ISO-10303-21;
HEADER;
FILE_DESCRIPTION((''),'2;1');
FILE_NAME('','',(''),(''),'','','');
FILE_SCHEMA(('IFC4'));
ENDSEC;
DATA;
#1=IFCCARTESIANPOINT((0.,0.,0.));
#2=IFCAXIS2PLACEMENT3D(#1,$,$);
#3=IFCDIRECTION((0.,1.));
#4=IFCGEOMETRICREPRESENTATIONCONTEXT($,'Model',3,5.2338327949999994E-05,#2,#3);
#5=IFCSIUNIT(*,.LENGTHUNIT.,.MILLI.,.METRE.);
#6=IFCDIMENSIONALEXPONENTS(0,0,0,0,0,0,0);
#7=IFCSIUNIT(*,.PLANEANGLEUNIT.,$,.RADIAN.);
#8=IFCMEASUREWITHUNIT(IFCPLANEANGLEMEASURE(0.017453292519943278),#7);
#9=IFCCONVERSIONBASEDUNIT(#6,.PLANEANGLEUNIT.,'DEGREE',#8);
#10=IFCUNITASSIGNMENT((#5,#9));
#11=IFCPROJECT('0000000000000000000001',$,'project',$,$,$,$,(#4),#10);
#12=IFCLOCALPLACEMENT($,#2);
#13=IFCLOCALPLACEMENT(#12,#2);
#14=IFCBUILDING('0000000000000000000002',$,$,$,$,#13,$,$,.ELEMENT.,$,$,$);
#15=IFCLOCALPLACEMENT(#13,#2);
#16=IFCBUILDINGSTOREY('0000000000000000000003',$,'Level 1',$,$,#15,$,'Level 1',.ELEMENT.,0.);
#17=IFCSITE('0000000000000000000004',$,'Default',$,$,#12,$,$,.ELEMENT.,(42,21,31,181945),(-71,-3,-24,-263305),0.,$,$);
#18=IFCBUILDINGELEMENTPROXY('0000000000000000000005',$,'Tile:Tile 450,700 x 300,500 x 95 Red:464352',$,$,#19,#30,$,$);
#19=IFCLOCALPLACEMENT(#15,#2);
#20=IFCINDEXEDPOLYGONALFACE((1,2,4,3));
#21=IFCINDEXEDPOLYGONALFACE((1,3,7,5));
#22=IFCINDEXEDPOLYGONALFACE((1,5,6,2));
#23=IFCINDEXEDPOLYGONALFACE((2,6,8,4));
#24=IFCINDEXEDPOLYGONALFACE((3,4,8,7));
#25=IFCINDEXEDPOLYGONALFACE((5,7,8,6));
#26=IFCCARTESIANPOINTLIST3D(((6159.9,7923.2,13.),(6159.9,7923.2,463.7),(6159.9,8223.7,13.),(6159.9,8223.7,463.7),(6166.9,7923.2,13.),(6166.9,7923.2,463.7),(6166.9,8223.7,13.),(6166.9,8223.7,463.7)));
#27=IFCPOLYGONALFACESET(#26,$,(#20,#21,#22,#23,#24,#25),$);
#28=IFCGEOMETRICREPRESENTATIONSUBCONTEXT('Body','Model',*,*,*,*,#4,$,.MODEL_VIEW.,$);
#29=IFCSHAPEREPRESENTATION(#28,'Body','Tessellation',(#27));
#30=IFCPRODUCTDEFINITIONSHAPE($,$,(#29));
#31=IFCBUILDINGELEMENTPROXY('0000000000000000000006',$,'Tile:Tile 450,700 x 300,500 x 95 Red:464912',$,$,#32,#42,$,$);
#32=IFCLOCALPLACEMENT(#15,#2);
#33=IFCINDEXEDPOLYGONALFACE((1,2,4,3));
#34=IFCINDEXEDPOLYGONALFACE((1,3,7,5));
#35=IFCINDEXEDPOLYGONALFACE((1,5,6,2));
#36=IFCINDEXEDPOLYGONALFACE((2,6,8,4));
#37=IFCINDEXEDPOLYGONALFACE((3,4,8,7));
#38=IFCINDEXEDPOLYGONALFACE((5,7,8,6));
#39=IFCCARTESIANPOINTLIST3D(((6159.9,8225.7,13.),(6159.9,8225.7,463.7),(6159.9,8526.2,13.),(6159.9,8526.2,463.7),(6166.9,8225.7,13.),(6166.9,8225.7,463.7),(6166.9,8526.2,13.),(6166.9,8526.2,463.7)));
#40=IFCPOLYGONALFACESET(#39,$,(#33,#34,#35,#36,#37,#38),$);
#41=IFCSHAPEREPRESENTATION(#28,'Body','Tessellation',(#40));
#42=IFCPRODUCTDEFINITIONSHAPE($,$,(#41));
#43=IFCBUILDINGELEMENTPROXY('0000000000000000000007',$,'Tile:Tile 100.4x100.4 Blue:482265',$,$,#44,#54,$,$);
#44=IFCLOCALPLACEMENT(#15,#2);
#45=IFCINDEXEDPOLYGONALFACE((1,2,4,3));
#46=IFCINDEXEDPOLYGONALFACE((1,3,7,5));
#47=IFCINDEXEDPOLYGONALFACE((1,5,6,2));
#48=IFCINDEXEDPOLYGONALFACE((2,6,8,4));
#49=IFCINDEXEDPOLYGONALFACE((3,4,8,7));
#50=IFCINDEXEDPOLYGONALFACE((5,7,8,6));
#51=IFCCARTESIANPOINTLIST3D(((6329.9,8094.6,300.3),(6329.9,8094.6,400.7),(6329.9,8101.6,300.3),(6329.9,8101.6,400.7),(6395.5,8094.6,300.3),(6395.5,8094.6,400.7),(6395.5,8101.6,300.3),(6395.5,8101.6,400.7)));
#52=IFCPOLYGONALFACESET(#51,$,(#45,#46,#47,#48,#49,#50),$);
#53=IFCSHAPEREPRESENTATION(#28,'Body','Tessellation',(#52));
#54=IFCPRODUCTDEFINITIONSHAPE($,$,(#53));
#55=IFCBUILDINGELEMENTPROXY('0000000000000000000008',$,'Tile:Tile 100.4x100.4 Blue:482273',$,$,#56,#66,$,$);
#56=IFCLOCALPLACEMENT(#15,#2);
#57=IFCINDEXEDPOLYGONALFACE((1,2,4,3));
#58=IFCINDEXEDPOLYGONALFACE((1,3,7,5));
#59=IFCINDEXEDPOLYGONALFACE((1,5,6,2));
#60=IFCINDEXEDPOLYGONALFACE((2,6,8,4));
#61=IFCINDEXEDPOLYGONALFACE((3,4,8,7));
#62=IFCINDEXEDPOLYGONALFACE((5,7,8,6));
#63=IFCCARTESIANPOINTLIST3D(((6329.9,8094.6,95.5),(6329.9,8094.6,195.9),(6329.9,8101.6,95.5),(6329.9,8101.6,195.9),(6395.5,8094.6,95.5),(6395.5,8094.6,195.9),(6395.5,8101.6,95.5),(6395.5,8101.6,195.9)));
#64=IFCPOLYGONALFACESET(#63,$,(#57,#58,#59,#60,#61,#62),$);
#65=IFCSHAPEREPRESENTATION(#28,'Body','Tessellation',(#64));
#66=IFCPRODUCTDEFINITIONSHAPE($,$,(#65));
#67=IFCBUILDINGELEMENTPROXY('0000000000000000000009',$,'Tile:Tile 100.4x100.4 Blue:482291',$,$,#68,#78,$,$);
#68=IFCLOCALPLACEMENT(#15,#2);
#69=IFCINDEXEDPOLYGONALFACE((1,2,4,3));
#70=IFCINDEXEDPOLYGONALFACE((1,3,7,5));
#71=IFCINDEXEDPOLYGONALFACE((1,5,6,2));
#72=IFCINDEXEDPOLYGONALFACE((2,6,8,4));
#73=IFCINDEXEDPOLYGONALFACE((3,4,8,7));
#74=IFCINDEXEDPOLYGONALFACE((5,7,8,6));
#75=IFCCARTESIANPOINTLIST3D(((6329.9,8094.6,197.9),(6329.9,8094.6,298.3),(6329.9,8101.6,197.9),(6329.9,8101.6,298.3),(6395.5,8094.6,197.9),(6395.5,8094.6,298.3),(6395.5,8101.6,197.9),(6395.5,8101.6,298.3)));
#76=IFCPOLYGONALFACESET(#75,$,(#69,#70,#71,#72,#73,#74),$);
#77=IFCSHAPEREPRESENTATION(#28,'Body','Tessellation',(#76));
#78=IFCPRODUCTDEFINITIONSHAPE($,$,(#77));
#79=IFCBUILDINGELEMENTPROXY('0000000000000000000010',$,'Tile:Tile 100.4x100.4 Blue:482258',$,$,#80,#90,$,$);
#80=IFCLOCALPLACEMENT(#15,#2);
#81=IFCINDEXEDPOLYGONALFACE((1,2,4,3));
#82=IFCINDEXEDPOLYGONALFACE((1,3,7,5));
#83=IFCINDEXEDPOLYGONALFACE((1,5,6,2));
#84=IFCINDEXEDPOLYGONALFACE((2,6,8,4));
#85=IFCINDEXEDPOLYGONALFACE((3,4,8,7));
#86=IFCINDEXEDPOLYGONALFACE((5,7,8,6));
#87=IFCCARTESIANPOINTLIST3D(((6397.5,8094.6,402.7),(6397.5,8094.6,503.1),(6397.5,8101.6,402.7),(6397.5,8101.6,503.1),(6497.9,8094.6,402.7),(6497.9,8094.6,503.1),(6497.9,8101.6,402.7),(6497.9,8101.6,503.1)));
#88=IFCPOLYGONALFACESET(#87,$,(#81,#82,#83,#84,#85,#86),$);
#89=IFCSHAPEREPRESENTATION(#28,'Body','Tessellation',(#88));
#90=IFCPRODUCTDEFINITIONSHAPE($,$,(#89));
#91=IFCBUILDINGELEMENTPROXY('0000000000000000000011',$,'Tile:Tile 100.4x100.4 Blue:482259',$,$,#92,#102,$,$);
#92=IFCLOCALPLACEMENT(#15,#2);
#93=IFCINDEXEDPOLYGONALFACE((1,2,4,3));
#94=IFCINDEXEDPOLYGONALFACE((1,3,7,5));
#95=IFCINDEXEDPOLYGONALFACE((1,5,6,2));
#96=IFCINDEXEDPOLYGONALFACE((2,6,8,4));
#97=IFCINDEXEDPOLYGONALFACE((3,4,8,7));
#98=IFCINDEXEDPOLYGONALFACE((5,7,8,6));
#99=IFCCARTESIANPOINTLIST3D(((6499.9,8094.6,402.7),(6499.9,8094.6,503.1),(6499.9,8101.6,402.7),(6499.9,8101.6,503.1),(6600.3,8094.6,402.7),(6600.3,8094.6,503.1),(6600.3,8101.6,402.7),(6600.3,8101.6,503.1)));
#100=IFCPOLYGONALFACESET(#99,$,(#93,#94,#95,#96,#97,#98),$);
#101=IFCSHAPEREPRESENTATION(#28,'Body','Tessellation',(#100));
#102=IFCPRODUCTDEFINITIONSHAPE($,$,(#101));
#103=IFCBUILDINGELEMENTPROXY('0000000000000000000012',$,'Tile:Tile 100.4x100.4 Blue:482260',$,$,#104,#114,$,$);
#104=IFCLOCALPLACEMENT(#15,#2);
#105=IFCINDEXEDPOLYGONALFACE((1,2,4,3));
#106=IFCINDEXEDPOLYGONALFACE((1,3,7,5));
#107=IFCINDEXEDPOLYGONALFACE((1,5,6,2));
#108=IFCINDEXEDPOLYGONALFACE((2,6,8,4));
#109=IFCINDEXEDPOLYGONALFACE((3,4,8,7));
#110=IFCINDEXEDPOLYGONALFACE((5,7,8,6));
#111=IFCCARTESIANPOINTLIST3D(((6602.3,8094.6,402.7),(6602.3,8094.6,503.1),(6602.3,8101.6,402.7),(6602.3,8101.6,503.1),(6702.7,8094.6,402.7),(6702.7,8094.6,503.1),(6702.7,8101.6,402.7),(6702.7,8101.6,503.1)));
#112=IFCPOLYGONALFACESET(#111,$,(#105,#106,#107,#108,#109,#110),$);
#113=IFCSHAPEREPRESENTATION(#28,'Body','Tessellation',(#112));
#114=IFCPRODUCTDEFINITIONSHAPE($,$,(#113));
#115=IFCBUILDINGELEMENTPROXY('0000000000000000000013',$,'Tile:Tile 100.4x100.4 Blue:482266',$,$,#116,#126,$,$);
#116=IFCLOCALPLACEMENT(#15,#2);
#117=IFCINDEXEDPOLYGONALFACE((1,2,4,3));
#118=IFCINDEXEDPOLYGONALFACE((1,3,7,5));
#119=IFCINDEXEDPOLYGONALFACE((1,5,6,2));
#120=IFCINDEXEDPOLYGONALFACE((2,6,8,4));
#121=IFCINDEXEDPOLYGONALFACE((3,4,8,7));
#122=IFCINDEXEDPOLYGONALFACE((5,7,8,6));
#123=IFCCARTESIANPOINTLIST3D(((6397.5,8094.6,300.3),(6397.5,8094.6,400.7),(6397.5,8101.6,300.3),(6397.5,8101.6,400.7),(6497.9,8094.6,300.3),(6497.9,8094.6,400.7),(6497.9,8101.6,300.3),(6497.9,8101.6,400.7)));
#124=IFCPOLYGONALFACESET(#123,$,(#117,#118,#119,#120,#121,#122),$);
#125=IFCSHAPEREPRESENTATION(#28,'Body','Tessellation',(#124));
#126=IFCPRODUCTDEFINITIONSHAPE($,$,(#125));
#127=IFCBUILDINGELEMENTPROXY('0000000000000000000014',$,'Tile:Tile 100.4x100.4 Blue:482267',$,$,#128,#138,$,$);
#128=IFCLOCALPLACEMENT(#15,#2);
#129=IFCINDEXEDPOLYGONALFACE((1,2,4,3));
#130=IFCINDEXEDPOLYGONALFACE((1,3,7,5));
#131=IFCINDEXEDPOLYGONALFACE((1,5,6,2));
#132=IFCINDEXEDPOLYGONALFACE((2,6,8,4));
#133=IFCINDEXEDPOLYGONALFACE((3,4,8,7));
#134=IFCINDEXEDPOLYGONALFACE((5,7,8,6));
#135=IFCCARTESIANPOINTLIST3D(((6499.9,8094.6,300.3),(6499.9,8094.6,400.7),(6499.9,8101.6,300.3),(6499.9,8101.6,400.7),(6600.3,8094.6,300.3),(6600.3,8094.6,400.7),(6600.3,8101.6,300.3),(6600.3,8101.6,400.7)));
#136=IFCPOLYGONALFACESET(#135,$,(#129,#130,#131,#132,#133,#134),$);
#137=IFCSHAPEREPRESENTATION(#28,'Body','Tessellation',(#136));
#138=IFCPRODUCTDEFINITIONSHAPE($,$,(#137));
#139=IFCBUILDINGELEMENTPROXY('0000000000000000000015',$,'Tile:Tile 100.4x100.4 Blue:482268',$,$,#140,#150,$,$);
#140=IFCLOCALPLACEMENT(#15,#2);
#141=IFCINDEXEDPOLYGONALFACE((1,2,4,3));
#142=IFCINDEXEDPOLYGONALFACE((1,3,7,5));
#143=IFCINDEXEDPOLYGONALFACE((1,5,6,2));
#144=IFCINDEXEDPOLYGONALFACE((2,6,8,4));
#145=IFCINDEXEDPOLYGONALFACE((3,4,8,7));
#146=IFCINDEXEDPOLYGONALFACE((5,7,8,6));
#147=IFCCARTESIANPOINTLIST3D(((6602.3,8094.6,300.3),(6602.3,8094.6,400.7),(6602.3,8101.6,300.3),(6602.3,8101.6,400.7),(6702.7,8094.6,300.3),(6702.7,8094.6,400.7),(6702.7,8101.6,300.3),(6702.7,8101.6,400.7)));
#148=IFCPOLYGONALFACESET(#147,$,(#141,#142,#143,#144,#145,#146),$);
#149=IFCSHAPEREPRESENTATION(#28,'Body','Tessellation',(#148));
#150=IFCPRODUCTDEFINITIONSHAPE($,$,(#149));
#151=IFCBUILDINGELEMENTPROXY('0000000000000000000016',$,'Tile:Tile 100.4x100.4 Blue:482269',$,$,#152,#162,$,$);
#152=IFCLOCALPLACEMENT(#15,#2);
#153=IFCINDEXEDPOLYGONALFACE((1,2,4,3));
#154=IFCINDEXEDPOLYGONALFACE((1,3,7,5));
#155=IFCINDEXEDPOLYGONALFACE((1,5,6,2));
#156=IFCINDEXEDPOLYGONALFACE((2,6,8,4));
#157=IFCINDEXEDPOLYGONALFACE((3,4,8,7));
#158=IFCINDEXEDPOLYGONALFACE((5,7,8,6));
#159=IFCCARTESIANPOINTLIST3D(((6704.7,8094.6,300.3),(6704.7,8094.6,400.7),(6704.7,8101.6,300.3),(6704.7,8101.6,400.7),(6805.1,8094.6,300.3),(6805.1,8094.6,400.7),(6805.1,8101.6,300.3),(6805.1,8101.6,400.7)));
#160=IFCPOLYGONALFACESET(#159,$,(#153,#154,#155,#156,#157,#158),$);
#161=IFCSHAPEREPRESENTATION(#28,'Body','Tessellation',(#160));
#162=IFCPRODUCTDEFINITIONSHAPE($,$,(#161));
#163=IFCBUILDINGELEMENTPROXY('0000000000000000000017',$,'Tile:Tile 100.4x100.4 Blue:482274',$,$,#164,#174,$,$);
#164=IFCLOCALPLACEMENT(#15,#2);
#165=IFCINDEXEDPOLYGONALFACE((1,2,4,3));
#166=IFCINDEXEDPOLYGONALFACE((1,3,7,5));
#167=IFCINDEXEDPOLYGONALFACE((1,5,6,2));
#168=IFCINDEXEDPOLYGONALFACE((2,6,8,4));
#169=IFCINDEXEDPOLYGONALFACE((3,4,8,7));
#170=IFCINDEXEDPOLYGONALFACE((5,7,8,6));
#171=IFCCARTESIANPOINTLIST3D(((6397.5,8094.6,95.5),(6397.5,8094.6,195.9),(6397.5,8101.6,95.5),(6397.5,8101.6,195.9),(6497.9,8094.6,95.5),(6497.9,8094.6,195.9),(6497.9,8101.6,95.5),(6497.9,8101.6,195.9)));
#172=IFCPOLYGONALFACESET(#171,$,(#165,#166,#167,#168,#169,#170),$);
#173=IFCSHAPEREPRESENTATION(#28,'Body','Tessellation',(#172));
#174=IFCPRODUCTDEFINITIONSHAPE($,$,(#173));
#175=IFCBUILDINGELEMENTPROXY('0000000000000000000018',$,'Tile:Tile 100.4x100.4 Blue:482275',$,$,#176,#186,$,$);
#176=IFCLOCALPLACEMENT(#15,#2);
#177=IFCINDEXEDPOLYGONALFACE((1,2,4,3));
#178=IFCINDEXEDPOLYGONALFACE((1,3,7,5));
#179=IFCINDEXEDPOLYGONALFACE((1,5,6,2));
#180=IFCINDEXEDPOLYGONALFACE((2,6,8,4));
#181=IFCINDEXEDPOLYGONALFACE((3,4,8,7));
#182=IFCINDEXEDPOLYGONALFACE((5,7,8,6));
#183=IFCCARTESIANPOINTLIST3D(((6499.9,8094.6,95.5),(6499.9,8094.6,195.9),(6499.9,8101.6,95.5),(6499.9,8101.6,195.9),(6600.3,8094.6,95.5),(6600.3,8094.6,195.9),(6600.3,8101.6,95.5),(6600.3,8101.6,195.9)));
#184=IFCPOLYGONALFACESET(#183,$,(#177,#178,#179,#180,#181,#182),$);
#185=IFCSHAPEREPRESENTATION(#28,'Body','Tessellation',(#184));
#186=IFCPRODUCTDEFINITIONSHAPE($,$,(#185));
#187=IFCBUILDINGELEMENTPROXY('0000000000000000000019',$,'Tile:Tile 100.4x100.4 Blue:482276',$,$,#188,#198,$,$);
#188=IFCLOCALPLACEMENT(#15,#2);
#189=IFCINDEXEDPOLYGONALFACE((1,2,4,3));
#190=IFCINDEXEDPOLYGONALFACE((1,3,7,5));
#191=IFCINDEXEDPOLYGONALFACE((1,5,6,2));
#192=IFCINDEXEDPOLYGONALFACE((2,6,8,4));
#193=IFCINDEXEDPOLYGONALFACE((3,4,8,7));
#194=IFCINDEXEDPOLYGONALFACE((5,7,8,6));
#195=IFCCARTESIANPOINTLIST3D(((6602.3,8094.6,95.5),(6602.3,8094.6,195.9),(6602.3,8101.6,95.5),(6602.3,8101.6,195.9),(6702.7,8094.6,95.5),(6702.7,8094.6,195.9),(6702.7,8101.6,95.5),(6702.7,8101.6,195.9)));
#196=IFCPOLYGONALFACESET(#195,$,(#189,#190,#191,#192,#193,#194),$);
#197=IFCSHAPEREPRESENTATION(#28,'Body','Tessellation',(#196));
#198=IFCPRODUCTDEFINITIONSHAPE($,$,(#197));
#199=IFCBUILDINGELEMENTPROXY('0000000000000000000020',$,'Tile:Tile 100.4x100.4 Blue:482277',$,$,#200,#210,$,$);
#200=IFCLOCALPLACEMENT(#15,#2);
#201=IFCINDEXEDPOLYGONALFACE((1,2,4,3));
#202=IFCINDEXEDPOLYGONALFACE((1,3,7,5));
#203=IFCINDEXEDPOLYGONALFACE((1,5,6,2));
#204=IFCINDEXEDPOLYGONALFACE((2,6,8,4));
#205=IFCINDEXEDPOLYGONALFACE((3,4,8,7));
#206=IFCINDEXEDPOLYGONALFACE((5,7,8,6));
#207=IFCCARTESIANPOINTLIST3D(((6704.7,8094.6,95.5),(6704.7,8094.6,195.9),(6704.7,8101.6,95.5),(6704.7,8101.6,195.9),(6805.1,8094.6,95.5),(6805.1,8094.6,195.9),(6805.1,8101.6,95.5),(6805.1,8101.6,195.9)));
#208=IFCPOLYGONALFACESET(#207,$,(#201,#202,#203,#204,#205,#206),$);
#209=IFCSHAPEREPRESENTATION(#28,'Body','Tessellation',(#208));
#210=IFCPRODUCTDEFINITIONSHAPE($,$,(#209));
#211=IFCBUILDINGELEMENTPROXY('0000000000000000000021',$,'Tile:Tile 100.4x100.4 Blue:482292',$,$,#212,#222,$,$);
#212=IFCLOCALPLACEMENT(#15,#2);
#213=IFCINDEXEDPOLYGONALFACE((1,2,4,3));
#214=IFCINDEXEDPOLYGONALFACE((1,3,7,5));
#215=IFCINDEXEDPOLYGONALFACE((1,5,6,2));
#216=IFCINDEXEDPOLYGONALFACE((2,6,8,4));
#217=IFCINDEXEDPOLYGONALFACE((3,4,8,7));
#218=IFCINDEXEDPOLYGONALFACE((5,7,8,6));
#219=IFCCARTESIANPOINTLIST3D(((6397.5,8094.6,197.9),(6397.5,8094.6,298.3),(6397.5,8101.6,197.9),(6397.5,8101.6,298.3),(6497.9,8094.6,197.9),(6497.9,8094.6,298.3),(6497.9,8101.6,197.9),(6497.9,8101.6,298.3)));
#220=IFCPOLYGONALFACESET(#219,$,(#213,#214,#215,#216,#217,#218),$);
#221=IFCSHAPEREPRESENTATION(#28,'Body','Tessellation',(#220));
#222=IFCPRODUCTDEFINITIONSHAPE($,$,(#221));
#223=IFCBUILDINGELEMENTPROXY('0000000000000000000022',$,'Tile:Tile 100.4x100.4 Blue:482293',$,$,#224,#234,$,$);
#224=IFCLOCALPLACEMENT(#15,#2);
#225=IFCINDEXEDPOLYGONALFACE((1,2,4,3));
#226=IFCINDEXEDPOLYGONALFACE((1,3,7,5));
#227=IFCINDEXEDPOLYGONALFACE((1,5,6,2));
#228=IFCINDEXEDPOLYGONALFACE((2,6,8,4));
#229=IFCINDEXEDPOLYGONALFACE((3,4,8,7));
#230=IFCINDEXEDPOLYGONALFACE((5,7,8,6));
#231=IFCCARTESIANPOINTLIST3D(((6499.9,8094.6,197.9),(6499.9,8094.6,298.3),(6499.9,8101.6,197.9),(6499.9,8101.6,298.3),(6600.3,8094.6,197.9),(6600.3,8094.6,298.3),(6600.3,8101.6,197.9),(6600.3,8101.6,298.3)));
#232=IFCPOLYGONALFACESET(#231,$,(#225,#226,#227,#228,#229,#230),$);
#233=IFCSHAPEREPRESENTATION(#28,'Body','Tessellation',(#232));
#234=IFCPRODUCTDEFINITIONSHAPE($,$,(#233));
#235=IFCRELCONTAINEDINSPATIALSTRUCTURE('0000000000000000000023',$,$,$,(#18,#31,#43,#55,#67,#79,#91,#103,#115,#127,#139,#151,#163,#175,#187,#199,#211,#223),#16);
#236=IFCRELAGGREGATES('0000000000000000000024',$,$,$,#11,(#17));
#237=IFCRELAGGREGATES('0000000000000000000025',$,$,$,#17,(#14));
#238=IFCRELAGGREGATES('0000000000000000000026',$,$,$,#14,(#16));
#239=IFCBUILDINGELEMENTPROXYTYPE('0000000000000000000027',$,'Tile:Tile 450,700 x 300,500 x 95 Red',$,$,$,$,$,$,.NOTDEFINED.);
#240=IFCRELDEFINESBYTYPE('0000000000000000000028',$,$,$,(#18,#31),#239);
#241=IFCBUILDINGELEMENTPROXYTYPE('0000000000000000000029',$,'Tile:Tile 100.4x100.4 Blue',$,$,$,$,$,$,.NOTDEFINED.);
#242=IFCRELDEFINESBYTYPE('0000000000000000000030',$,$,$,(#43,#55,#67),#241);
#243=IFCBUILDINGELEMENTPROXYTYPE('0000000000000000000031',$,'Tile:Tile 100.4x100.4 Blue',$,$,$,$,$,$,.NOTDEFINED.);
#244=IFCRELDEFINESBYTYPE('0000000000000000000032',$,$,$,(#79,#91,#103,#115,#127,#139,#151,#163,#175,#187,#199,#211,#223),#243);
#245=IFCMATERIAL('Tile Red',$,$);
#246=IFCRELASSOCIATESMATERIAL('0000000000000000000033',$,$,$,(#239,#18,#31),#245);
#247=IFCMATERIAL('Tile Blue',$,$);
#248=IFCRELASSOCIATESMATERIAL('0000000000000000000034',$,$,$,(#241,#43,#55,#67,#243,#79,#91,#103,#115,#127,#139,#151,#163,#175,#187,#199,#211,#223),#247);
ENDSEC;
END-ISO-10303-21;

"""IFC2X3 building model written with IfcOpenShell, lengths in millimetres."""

from ifc_helpers import new_model, entity, si_unit, converted_unit, direction, frame, frame_2d, origin, origin_2d_with_axis, place, context, subcontext, project, spatial, rectangle, extrude, source, transform, mapped, material, type_object, type_shapes, element, save


model = new_model("IFC2X3")

# Units and contexts
model_context = context("Model", 3, precision=5.2338327949999994e-05, world=origin(), true_north=direction((0.0, 1.0)))
body_context = subcontext(model_context, "Body", "Model", "MODEL_VIEW")
ifc_project = project(units=[si_unit("LENGTHUNIT", "METRE", prefix="MILLI"), converted_unit("PLANEANGLEUNIT", "DEGREE", entity("IfcPlaneAngleMeasure", 0.017453292519943278), si_unit("PLANEANGLEUNIT", "RADIAN"), dimensions=[0, 0, 0, 0, 0, 0, 0])], contexts=[model_context])

# Site, building, storey
site_placement = place(None, origin())
site = spatial("IfcSite", under=ifc_project, at=site_placement, Name="Default", CompositionType="ELEMENT", RefLatitude=(42, 21, 31, 181945), RefLongitude=(-71, -3, -24, -263305), RefElevation=0.0)
building_placement = place(site_placement, origin())
building = spatial("IfcBuilding", under=site, at=building_placement, CompositionType="ELEMENT")
storey_placement = place(building_placement, origin())
storey = spatial("IfcBuildingStorey", under=building, at=storey_placement, Name="Level 1", LongName="Level 1", CompositionType="ELEMENT", Elevation=0.0)

# Building element proxies
ifc_material_1 = material(Name="Tile Red")
building_element_proxy_type_1 = type_object("IfcBuildingElementProxyType", Name="Tile:Tile 450,700 x 300,500 x 95 Red", PredefinedType="NOTDEFINED", material=ifc_material_1)
shared_shape_1 = source(origin(), body_context, "Body", "SweptSolid", [
    extrude(rectangle(XDim=300.5, YDim=450.7, at=frame_2d((0.0, 0.0), x_axis=(1.0, 0.0))), frame((-150.2, 225.4, 0.0)), (0.0, 0.0, 1.0), 7.0),
])
type_shapes(building_element_proxy_type_1, [shared_shape_1])
for number, where, z_axis, x_axis, name in (
    (1, (6166.9, 7923.2, 13.0), (-1.0, 0.0, 0.0), (0.0, -1.0, 0.0), "Tile:Tile 450,700 x 300,500 x 95 Red:464352"),
    (2, (6166.9, 8225.7, 13.0), (-1.0, 0.0, 0.0), (0.0, -1.0, 0.0), "Tile:Tile 450,700 x 300,500 x 95 Red:464912"),
):
    element("IfcBuildingElementProxy", number, at=place(storey_placement, frame(where, z_axis=z_axis, x_axis=x_axis)), inside=storey, type_object=building_element_proxy_type_1, material=ifc_material_1, Name=name, context=body_context, shape_type="MappedRepresentation", body=[
        mapped(shared_shape_1, transform((0.0, 0.0, 0.0), scale=1.0)),
    ])
ifc_material_2 = material(Name="Tile Blue")
building_element_proxy_type_2 = type_object("IfcBuildingElementProxyType", Name="Tile:Tile 100.4x100.4 Blue", PredefinedType="NOTDEFINED", material=ifc_material_2)
shared_shape_2 = source(origin(), body_context, "Body", "SweptSolid", [
    extrude(rectangle(XDim=65.6, YDim=100.4, at=frame_2d((0.0, 0.0), x_axis=(1.0, 0.0))), frame((-32.8, -50.2, 0.0), z_axis=(0.0, 0.0, 1.0), x_axis=(-1.0, 0.0, 0.0)), (0.0, 0.0, 1.0), 7.0),
])
type_shapes(building_element_proxy_type_2, [shared_shape_2])
for number, where, z_axis, x_axis, name in (
    (3, (6329.9, 8101.6, 300.3), (0.0, -1.0, 0.0), (-1.0, 0.0, 0.0), "Tile:Tile 100.4x100.4 Blue:482265"),
    (4, (6329.9, 8101.6, 95.5), (0.0, -1.0, 0.0), (-1.0, 0.0, 0.0), "Tile:Tile 100.4x100.4 Blue:482273"),
    (5, (6329.9, 8101.6, 197.9), (0.0, -1.0, 0.0), (-1.0, 0.0, 0.0), "Tile:Tile 100.4x100.4 Blue:482291"),
):
    element("IfcBuildingElementProxy", number, at=place(storey_placement, frame(where, z_axis=z_axis, x_axis=x_axis)), inside=storey, type_object=building_element_proxy_type_2, material=ifc_material_2, Name=name, context=body_context, shape_type="MappedRepresentation", body=[
        mapped(shared_shape_2, transform((0.0, 0.0, 0.0), scale=1.0)),
    ])
building_element_proxy_type_3 = type_object("IfcBuildingElementProxyType", Name="Tile:Tile 100.4x100.4 Blue", PredefinedType="NOTDEFINED", material=ifc_material_2)
shared_shape_3 = source(origin(), body_context, "Body", "SweptSolid", [
    extrude(rectangle(XDim=100.4, YDim=100.4, at=origin_2d_with_axis()), frame((-50.2, -50.2, 0.0), z_axis=(0.0, 0.0, 1.0), x_axis=(0.0, -1.0, 0.0)), (0.0, 0.0, 1.0), 7.0),
])
type_shapes(building_element_proxy_type_3, [shared_shape_3])
for number, where, z_axis, x_axis, name in (
    (6, (6397.5, 8101.6, 402.7), (0.0, -1.0, 0.0), (-1.0, 0.0, 0.0), "Tile:Tile 100.4x100.4 Blue:482258"),
    (7, (6499.9, 8101.6, 402.7), (0.0, -1.0, 0.0), (-1.0, 0.0, 0.0), "Tile:Tile 100.4x100.4 Blue:482259"),
    (8, (6602.3, 8101.6, 402.7), (0.0, -1.0, 0.0), (-1.0, 0.0, 0.0), "Tile:Tile 100.4x100.4 Blue:482260"),
    (9, (6397.5, 8101.6, 300.3), (0.0, -1.0, 0.0), (-1.0, 0.0, 0.0), "Tile:Tile 100.4x100.4 Blue:482266"),
    (10, (6499.9, 8101.6, 300.3), (0.0, -1.0, 0.0), (-1.0, 0.0, 0.0), "Tile:Tile 100.4x100.4 Blue:482267"),
    (11, (6602.3, 8101.6, 300.3), (0.0, -1.0, 0.0), (-1.0, 0.0, 0.0), "Tile:Tile 100.4x100.4 Blue:482268"),
    (12, (6704.7, 8101.6, 300.3), (0.0, -1.0, 0.0), (-1.0, 0.0, 0.0), "Tile:Tile 100.4x100.4 Blue:482269"),
    (13, (6397.5, 8101.6, 95.5), (0.0, -1.0, 0.0), (-1.0, 0.0, 0.0), "Tile:Tile 100.4x100.4 Blue:482274"),
    (14, (6499.9, 8101.6, 95.5), (0.0, -1.0, 0.0), (-1.0, 0.0, 0.0), "Tile:Tile 100.4x100.4 Blue:482275"),
    (15, (6602.3, 8101.6, 95.5), (0.0, -1.0, 0.0), (-1.0, 0.0, 0.0), "Tile:Tile 100.4x100.4 Blue:482276"),
    (16, (6704.7, 8101.6, 95.5), (0.0, -1.0, 0.0), (-1.0, 0.0, 0.0), "Tile:Tile 100.4x100.4 Blue:482277"),
    (17, (6397.5, 8101.6, 197.9), (0.0, -1.0, 0.0), (-1.0, 0.0, 0.0), "Tile:Tile 100.4x100.4 Blue:482292"),
    (18, (6499.9, 8101.6, 197.9), (0.0, -1.0, 0.0), (-1.0, 0.0, 0.0), "Tile:Tile 100.4x100.4 Blue:482293"),
):
    element("IfcBuildingElementProxy", number, at=place(storey_placement, frame(where, z_axis=z_axis, x_axis=x_axis)), inside=storey, type_object=building_element_proxy_type_3, material=ifc_material_2, Name=name, context=body_context, shape_type="MappedRepresentation", body=[
        mapped(shared_shape_3, transform((0.0, 0.0, 0.0), scale=1.0)),
    ])

save(model, "model.ifc")
